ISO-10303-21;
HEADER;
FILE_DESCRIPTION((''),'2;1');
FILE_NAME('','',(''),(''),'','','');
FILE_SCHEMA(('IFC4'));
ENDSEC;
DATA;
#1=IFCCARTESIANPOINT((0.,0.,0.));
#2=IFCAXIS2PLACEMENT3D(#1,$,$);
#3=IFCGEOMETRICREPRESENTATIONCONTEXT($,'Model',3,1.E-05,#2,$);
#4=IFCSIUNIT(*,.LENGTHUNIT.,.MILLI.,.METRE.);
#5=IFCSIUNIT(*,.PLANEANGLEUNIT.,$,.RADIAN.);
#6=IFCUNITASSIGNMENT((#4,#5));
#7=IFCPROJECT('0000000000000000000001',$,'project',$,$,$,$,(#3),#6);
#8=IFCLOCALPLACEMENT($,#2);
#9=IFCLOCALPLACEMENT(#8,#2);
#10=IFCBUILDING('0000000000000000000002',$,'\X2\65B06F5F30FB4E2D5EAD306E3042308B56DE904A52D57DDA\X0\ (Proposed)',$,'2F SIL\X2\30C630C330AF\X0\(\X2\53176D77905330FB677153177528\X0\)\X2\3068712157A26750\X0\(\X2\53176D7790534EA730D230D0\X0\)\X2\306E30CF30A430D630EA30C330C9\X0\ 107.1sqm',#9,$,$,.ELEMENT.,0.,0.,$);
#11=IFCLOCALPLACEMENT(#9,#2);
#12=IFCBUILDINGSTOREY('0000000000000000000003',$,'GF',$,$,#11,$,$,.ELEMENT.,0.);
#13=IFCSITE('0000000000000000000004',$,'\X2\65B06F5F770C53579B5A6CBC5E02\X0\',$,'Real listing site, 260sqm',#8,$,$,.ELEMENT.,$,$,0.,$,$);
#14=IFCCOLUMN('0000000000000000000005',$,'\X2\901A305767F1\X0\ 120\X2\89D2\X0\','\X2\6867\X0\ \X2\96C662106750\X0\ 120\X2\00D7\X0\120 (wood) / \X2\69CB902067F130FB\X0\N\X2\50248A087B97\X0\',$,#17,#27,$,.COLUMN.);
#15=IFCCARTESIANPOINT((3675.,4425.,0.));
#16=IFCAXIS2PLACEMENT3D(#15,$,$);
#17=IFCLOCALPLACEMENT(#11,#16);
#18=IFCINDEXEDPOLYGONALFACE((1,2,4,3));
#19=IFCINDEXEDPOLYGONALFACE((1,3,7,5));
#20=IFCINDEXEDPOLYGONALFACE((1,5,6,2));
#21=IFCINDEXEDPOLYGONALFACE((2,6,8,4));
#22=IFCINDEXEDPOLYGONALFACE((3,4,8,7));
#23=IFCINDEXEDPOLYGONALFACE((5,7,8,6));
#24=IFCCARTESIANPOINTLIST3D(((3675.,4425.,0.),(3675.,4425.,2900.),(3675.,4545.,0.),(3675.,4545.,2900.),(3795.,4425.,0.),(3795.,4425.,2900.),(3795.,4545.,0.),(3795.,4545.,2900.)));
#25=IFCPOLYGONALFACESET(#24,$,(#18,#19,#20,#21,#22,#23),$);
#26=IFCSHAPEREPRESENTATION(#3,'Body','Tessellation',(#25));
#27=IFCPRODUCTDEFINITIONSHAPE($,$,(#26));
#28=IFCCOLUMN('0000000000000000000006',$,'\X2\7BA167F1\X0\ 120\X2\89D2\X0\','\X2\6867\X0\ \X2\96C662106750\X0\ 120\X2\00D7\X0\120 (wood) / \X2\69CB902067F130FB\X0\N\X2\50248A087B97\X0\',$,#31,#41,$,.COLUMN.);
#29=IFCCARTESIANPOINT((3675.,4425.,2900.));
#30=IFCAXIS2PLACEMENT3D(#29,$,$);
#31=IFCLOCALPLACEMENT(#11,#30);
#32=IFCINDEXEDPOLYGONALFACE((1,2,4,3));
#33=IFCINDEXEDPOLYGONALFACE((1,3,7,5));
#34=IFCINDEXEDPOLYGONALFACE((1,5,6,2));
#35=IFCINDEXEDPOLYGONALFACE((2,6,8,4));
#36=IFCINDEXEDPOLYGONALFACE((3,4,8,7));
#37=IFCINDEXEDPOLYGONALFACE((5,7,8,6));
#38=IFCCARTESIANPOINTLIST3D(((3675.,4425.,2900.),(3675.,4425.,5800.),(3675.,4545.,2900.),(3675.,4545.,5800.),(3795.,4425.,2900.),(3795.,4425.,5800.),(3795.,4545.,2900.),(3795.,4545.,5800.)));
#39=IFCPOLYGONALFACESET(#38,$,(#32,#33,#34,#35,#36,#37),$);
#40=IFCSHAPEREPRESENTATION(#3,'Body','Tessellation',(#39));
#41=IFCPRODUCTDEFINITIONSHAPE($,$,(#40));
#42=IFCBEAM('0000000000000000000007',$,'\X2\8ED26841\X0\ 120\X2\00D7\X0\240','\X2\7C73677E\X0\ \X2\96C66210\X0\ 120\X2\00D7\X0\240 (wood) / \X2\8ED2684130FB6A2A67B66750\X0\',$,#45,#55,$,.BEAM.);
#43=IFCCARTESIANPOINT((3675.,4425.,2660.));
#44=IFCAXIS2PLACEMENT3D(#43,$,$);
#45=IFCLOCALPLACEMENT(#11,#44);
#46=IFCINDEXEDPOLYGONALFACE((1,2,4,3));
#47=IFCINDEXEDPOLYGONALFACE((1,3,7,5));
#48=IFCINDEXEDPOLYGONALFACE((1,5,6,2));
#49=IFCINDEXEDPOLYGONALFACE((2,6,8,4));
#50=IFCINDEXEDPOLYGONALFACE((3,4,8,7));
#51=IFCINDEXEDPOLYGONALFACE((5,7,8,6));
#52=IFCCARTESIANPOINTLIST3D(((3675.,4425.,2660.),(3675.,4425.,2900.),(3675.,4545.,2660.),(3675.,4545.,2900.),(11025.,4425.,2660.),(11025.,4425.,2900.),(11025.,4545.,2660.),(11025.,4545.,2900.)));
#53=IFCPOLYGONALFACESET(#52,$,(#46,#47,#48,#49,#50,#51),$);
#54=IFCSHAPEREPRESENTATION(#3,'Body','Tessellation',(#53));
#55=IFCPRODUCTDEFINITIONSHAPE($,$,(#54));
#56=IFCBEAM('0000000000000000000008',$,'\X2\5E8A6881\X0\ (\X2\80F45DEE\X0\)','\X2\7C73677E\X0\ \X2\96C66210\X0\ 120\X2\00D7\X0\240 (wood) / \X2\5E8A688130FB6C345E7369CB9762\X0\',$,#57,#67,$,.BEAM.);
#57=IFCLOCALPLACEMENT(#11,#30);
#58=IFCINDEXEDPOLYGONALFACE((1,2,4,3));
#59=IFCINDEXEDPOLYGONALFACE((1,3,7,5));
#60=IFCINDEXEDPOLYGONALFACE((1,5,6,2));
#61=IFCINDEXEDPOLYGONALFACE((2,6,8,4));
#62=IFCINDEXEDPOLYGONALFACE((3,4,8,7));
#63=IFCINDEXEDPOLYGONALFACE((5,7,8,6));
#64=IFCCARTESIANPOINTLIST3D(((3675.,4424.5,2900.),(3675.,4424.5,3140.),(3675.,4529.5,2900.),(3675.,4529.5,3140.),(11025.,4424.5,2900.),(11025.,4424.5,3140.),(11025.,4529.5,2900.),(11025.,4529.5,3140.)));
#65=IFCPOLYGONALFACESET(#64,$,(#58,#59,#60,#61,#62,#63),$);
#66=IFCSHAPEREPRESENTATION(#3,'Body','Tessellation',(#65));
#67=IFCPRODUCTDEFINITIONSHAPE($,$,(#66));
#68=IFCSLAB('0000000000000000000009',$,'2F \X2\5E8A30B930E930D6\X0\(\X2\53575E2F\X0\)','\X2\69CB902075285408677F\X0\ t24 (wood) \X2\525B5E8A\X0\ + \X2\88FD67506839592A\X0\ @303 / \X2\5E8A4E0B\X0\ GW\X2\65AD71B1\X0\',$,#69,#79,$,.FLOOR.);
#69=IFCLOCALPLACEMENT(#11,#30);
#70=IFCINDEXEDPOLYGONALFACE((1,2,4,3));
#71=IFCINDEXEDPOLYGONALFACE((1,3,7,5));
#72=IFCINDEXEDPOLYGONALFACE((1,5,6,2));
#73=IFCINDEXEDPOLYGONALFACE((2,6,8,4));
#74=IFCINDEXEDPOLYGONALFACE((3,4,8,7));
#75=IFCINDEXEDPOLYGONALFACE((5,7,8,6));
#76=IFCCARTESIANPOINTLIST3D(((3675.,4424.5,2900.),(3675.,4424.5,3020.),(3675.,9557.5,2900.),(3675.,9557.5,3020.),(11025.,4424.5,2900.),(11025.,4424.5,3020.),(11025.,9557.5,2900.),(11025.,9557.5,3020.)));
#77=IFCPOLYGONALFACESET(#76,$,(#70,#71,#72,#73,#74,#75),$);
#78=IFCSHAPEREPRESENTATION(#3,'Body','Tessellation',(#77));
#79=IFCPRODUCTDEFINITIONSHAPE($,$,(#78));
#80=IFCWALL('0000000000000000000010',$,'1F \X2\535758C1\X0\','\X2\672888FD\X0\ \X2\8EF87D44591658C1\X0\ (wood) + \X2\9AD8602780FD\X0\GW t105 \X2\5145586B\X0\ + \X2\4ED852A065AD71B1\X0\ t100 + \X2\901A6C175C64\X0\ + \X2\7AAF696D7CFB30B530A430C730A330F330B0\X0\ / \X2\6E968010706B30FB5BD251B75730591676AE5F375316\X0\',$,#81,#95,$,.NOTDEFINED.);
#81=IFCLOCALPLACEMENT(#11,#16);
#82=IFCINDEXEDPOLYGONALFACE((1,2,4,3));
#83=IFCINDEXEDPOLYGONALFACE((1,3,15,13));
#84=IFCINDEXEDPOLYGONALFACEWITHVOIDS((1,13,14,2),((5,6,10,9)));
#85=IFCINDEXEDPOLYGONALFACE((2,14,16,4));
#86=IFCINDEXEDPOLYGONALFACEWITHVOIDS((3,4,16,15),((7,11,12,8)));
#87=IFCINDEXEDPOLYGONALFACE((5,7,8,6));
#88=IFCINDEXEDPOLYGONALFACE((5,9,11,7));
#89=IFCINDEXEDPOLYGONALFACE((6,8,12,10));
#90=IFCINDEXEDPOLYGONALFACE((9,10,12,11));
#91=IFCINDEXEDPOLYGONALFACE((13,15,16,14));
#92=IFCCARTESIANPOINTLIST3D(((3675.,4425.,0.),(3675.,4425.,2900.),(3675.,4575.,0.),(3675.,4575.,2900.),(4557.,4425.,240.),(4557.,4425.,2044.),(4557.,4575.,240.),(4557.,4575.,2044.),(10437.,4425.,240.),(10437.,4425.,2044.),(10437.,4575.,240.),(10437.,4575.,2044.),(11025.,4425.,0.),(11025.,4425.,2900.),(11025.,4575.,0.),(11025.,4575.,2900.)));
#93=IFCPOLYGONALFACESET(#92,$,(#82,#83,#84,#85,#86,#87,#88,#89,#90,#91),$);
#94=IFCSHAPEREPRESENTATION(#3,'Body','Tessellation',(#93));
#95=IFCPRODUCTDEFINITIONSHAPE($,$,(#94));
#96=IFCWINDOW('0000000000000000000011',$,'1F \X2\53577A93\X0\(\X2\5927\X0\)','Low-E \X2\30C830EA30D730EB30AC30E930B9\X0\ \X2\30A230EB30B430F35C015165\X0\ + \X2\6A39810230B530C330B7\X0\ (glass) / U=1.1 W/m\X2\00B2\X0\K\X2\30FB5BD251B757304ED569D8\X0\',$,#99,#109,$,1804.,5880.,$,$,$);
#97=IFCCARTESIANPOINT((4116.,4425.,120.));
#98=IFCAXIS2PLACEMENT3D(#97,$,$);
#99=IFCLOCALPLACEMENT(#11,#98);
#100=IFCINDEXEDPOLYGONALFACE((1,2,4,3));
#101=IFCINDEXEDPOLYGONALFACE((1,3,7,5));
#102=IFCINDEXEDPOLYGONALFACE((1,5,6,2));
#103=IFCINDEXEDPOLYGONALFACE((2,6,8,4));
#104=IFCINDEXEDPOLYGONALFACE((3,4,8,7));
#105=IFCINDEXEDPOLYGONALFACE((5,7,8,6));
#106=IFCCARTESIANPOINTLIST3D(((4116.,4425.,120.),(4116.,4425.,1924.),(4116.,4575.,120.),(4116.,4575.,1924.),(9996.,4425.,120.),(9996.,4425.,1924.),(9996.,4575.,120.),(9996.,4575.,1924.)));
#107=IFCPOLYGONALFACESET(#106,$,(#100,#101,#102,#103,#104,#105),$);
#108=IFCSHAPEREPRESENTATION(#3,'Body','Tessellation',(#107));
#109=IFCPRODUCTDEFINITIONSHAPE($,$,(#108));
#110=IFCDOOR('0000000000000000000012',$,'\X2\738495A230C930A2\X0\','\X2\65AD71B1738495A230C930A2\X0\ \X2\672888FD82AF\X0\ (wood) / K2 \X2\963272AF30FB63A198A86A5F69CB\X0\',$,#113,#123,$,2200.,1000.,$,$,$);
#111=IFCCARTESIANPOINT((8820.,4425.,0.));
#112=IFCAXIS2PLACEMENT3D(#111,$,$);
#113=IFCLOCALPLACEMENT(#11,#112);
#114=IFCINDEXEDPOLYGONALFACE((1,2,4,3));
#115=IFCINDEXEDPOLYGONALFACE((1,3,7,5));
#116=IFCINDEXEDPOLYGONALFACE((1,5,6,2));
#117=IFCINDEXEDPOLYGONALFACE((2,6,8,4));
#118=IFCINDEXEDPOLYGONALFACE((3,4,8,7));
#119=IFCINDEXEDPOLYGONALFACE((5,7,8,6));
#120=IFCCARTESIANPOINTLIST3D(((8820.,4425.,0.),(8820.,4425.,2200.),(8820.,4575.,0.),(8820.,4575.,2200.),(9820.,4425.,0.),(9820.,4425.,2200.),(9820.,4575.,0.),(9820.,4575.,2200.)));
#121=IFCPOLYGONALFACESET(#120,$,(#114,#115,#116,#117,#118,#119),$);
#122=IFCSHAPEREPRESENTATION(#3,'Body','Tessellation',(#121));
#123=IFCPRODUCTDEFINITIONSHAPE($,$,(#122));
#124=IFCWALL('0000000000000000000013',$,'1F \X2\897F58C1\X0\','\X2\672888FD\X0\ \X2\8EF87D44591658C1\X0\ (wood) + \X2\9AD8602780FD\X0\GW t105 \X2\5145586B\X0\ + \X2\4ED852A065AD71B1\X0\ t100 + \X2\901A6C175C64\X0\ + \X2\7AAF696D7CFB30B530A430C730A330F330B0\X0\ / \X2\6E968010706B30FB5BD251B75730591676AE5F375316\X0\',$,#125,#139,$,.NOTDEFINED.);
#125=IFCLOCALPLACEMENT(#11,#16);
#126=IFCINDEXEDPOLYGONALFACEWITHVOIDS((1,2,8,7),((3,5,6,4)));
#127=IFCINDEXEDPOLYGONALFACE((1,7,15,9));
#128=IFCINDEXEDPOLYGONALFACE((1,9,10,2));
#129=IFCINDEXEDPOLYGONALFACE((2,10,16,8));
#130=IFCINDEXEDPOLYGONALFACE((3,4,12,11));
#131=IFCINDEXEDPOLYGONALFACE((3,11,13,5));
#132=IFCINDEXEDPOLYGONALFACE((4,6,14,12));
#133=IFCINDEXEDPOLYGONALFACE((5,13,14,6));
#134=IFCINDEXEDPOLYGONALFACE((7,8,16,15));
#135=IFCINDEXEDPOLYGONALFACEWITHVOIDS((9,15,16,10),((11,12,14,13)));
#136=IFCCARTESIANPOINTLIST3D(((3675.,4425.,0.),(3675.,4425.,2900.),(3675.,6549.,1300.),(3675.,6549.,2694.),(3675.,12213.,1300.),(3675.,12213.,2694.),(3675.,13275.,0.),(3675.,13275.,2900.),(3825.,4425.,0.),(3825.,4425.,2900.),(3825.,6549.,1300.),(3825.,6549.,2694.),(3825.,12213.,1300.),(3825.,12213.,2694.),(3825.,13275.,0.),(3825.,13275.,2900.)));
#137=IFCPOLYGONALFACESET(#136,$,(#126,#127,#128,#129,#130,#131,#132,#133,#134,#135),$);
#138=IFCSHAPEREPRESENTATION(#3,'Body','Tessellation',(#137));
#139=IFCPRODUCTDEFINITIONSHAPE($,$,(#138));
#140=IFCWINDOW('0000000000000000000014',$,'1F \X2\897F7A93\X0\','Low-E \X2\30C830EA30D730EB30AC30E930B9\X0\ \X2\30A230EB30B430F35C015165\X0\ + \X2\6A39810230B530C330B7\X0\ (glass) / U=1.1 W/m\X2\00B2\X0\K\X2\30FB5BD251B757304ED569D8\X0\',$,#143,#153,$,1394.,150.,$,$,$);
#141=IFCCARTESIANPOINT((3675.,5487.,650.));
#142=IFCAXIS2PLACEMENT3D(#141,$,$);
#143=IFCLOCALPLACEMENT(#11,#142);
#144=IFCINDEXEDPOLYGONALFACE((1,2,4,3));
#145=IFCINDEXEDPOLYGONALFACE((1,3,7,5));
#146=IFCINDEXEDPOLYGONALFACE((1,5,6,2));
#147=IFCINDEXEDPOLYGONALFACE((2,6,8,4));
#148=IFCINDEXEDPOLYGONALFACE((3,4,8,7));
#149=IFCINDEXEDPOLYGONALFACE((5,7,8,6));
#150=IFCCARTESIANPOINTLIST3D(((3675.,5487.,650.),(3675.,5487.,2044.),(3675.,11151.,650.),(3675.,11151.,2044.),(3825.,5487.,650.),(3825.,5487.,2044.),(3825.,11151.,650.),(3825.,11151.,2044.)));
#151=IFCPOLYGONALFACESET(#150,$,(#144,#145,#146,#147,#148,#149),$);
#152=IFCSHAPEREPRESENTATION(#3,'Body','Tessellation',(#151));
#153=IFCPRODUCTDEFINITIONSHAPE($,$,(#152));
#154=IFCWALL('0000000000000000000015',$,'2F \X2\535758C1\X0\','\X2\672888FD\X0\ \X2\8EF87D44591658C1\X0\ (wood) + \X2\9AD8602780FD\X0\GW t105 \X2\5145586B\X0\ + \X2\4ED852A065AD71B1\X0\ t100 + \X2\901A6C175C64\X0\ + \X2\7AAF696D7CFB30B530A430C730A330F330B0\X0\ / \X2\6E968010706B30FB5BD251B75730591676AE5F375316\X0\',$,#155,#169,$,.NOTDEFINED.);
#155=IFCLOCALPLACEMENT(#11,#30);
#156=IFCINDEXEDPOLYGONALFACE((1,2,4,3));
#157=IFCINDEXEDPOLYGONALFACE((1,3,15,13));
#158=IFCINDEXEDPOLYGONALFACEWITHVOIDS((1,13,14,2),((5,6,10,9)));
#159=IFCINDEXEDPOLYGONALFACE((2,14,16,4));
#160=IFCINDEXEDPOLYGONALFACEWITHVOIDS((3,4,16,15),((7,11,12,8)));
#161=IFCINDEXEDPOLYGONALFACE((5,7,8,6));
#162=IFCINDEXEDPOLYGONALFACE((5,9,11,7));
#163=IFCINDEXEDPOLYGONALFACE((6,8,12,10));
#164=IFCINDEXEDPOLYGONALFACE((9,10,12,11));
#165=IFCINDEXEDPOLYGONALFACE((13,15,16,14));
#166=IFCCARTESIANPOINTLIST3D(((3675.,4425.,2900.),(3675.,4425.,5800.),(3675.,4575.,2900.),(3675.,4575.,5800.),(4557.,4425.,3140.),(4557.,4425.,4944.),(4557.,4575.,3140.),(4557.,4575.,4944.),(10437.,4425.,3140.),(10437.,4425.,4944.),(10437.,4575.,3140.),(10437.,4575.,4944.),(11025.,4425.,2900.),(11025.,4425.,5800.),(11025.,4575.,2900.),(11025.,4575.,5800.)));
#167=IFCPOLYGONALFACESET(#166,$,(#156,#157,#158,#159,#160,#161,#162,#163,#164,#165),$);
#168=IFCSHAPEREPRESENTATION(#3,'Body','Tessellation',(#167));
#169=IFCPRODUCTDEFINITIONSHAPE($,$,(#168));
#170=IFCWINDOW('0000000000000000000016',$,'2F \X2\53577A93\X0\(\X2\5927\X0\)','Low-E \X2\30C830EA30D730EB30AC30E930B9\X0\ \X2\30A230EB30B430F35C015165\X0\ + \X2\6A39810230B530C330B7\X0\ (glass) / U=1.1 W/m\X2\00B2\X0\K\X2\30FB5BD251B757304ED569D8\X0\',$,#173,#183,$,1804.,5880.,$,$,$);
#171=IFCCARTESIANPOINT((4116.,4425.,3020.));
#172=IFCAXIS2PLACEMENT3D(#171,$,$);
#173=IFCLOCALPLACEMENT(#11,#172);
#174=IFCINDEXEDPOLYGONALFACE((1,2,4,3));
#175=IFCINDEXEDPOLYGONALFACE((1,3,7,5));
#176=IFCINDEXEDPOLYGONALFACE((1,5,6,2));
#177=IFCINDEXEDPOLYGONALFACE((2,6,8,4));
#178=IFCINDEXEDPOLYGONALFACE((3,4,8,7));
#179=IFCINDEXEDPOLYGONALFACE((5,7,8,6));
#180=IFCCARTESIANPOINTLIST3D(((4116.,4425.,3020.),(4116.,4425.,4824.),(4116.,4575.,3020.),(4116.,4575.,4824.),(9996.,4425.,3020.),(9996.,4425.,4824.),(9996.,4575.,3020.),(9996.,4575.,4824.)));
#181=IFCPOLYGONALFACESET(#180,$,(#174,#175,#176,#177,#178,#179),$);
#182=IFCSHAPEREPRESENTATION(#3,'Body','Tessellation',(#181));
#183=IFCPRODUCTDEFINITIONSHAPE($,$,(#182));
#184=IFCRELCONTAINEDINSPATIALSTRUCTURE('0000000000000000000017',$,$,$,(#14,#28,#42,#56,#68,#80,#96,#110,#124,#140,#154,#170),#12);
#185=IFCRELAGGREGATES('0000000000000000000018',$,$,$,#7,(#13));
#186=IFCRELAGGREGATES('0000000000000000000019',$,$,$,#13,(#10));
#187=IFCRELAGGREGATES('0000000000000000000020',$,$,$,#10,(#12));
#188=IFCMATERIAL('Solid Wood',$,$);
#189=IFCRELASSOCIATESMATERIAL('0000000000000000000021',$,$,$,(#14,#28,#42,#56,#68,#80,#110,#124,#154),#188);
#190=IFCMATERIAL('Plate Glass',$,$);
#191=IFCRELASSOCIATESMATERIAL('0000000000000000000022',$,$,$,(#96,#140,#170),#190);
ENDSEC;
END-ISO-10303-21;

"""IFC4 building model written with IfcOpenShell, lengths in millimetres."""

from ifc_helpers import new_model, si_unit, frame, frame_2d, origin, place, context, project, spatial, rectangle, extrude, material, element, fill, save


model = new_model("IFC4")

# Units and contexts
model_context = context("Model", 3, precision=1e-05, world=origin())
ifc_project = project(units=[si_unit("LENGTHUNIT", "METRE", prefix="MILLI"), si_unit("PLANEANGLEUNIT", "RADIAN")], contexts=[model_context])

# Site, building, storey
site_placement = place(None, origin())
site = spatial("IfcSite", under=ifc_project, at=site_placement, Name="新潟県南魚沼市", ObjectType="Real listing site, 260sqm", CompositionType="ELEMENT", RefElevation=0.0)
building_placement = place(site_placement, origin())
building = spatial("IfcBuilding", under=site, at=building_placement, Name="新潟・中庭のある回遊動線 (Proposed)", ObjectType="2F SILテック(北海道・東北用)と無垢材(北海道产ヒバ)のハイブリッド 107.1sqm", CompositionType="ELEMENT", ElevationOfRefHeight=0.0, ElevationOfTerrain=0.0)
storey_placement = place(building_placement, origin())
storey = spatial("IfcBuildingStorey", under=building, at=storey_placement, Name="GF", CompositionType="ELEMENT", Elevation=0.0)

# Columns
ifc_material_1 = material(Name="Solid Wood")
column_1_placement = place(storey_placement, frame((3675.0, 4425.0, 0.0)))
element("IfcColumn", 1, at=column_1_placement, inside=storey, material=ifc_material_1, Name="通し柱 120角", Description="桧 集成材 120×120 (wood) / 構造柱・N値計算", PredefinedType="COLUMN", context=model_context, shape_type="SweptSolid", body=[
    extrude(rectangle(XDim=120.0, YDim=120.0, at=frame_2d((60.0, 60.0))), frame((3675.0, 4425.0, 0.0)), (0.0, 0.0, 1.0), 2900.0),
])
column_2_placement = place(storey_placement, frame((3675.0, 4425.0, 2900.0)))
element("IfcColumn", 2, at=column_2_placement, inside=storey, material=ifc_material_1, Name="管柱 120角", Description="桧 集成材 120×120 (wood) / 構造柱・N値計算", PredefinedType="COLUMN", context=model_context, shape_type="SweptSolid", body=[
    extrude(rectangle(XDim=120.0, YDim=120.0, at=frame_2d((60.0, 60.0))), frame((3675.0, 4425.0, 2900.0)), (0.0, 0.0, 1.0), 2900.0),
])

# Beams
beam_1_placement = place(storey_placement, frame((3675.0, 4425.0, 2660.0)))
element("IfcBeam", 3, at=beam_1_placement, inside=storey, material=ifc_material_1, Name="軒桁 120×240", Description="米松 集成 120×240 (wood) / 軒桁・横架材", PredefinedType="BEAM", context=model_context, shape_type="SweptSolid", body=[
    extrude(rectangle(XDim=7350.0, YDim=120.0, at=frame_2d((3675.0, 60.0))), frame((3675.0, 4425.0, 2660.0)), (0.0, 0.0, 1.0), 240.0),
])
beam_2_placement = place(storey_placement, frame((3675.0, 4425.0, 2900.0)))
element("IfcBeam", 4, at=beam_2_placement, inside=storey, material=ifc_material_1, Name="床梁 (胴差)", Description="米松 集成 120×240 (wood) / 床梁・水平構面", PredefinedType="BEAM", context=model_context, shape_type="SweptSolid", body=[
    extrude(rectangle(XDim=7350.0, YDim=105.0, at=frame_2d((3675.0, 52.0))), frame((3675.0, 4425.0, 2900.0)), (0.0, 0.0, 1.0), 240.0),
])

# Slab
slab_1_placement = place(storey_placement, frame((3675.0, 4425.0, 2900.0)))
element("IfcSlab", 5, at=slab_1_placement, inside=storey, material=ifc_material_1, Name="2F 床スラブ(南帯)", Description="構造用合板 t24 (wood) 剛床 + 製材根太 @303 / 床下 GW断熱", PredefinedType="FLOOR", context=model_context, shape_type="SweptSolid", body=[
    extrude(rectangle(XDim=7350.0, YDim=5133.0, at=frame_2d((3675.0, 2566.0))), frame((3675.0, 4425.0, 2900.0)), (0.0, 0.0, 1.0), 120.0),
])

# Wall, openings, window, door
wall_1_placement = place(storey_placement, frame((3675.0, 4425.0, 0.0)))
wall_1 = element("IfcWall", 6, at=wall_1_placement, inside=storey, material=ifc_material_1, Name="1F 南壁", Description="木製 軸組外壁 (wood) + 高性能GW t105 充填 + 付加断熱 t100 + 通気層 + 窯業系サイディング / 準耐火・寒冷地外皮強化", PredefinedType="NOTDEFINED", context=model_context, shape_type="SweptSolid", body=[
    extrude(rectangle(XDim=7350.0, YDim=150.0, at=frame_2d((3675.0, 75.0))), frame((3675.0, 4425.0, 0.0)), (0.0, 0.0, 1.0), 2900.0),
])
opening_1_placement = place(storey_placement, frame((4116.0, 4425.0, 120.0)))
opening_1 = element("IfcOpeningElement", 7, at=opening_1_placement, cuts=wall_1, PredefinedType="NOTDEFINED", context=model_context, shape_type="SweptSolid", body=[
    extrude(rectangle(XDim=5880.0, YDim=150.0, at=frame_2d((2940.0, 75.0))), frame((4116.0, 4425.0, 120.0)), (0.0, 0.0, 1.0), 1804.0),
])
opening_2_placement = place(storey_placement, frame((8820.0, 4425.0, 0.0)))
opening_2 = element("IfcOpeningElement", 8, at=opening_2_placement, cuts=wall_1, PredefinedType="NOTDEFINED", context=model_context, shape_type="SweptSolid", body=[
    extrude(rectangle(XDim=1000.0, YDim=150.0, at=frame_2d((500.0, 75.0))), frame((8820.0, 4425.0, 0.0)), (0.0, 0.0, 1.0), 2200.0),
])
ifc_material_2 = material(Name="Plate Glass")
window_1_placement = place(storey_placement, frame((4116.0, 4425.0, 120.0)))
window_1 = element("IfcWindow", 9, at=window_1_placement, inside=storey, material=ifc_material_2, Name="1F 南窓(大)", Description="Low-E トリプルガラス アルゴン封入 + 樹脂サッシ (glass) / U=1.1 W/m²K・寒冷地仕様", OverallHeight=1804.0, OverallWidth=5880.0, context=model_context, shape_type="SweptSolid", body=[
    extrude(rectangle(XDim=5880.0, YDim=150.0, at=frame_2d((2940.0, 75.0))), frame((4116.0, 4425.0, 120.0)), (0.0, 0.0, 1.0), 1804.0),
])
fill(opening_1, window_1)
door_placement = place(storey_placement, frame((8820.0, 4425.0, 0.0)))
door = element("IfcDoor", 10, at=door_placement, inside=storey, material=ifc_material_1, Name="玄関ドア", Description="断熱玄関ドア 木製芯 (wood) / K2 防犯・採風機構", OverallHeight=2200.0, OverallWidth=1000.0, context=model_context, shape_type="SweptSolid", body=[
    extrude(rectangle(XDim=1000.0, YDim=150.0, at=frame_2d((500.0, 75.0))), frame((8820.0, 4425.0, 0.0)), (0.0, 0.0, 1.0), 2200.0),
])
fill(opening_2, door)

# Walls, openings, windows
wall_2_placement = place(storey_placement, frame((3675.0, 4425.0, 0.0)))
wall_2 = element("IfcWall", 11, at=wall_2_placement, inside=storey, material=ifc_material_1, Name="1F 西壁", Description="木製 軸組外壁 (wood) + 高性能GW t105 充填 + 付加断熱 t100 + 通気層 + 窯業系サイディング / 準耐火・寒冷地外皮強化", PredefinedType="NOTDEFINED", context=model_context, shape_type="SweptSolid", body=[
    extrude(rectangle(XDim=150.0, YDim=8850.0, at=frame_2d((75.0, 4425.0))), frame((3675.0, 4425.0, 0.0)), (0.0, 0.0, 1.0), 2900.0),
])
opening_3_placement = place(storey_placement, frame((3675.0, 5487.0, 650.0)))
opening_3 = element("IfcOpeningElement", 12, at=opening_3_placement, cuts=wall_2, PredefinedType="NOTDEFINED", context=model_context, shape_type="SweptSolid", body=[
    extrude(rectangle(XDim=150.0, YDim=5664.0, at=frame_2d((75.0, 2832.0))), frame((3675.0, 5487.0, 650.0)), (0.0, 0.0, 1.0), 1394.0),
])
window_2_placement = place(storey_placement, frame((3675.0, 5487.0, 650.0)))
window_2 = element("IfcWindow", 13, at=window_2_placement, inside=storey, material=ifc_material_2, Name="1F 西窓", Description="Low-E トリプルガラス アルゴン封入 + 樹脂サッシ (glass) / U=1.1 W/m²K・寒冷地仕様", OverallHeight=1394.0, OverallWidth=150.0, context=model_context, shape_type="SweptSolid", body=[
    extrude(rectangle(XDim=150.0, YDim=5664.0, at=frame_2d((75.0, 2832.0))), frame((3675.0, 5487.0, 650.0)), (0.0, 0.0, 1.0), 1394.0),
])
fill(opening_3, window_2)
wall_3_placement = place(storey_placement, frame((3675.0, 4425.0, 2900.0)))
wall_3 = element("IfcWall", 14, at=wall_3_placement, inside=storey, material=ifc_material_1, Name="2F 南壁", Description="木製 軸組外壁 (wood) + 高性能GW t105 充填 + 付加断熱 t100 + 通気層 + 窯業系サイディング / 準耐火・寒冷地外皮強化", PredefinedType="NOTDEFINED", context=model_context, shape_type="SweptSolid", body=[
    extrude(rectangle(XDim=7350.0, YDim=150.0, at=frame_2d((3675.0, 75.0))), frame((3675.0, 4425.0, 2900.0)), (0.0, 0.0, 1.0), 2900.0),
])
opening_4_placement = place(storey_placement, frame((4116.0, 4425.0, 3020.0)))
opening_4 = element("IfcOpeningElement", 15, at=opening_4_placement, cuts=wall_3, PredefinedType="NOTDEFINED", context=model_context, shape_type="SweptSolid", body=[
    extrude(rectangle(XDim=5880.0, YDim=150.0, at=frame_2d((2940.0, 75.0))), frame((4116.0, 4425.0, 3020.0)), (0.0, 0.0, 1.0), 1804.0),
])
window_3_placement = place(storey_placement, frame((4116.0, 4425.0, 3020.0)))
window_3 = element("IfcWindow", 16, at=window_3_placement, inside=storey, material=ifc_material_2, Name="2F 南窓(大)", Description="Low-E トリプルガラス アルゴン封入 + 樹脂サッシ (glass) / U=1.1 W/m²K・寒冷地仕様", OverallHeight=1804.0, OverallWidth=5880.0, context=model_context, shape_type="SweptSolid", body=[
    extrude(rectangle(XDim=5880.0, YDim=150.0, at=frame_2d((2940.0, 75.0))), frame((4116.0, 4425.0, 3020.0)), (0.0, 0.0, 1.0), 1804.0),
])
fill(opening_4, window_3)

save(model, "model.ifc")
